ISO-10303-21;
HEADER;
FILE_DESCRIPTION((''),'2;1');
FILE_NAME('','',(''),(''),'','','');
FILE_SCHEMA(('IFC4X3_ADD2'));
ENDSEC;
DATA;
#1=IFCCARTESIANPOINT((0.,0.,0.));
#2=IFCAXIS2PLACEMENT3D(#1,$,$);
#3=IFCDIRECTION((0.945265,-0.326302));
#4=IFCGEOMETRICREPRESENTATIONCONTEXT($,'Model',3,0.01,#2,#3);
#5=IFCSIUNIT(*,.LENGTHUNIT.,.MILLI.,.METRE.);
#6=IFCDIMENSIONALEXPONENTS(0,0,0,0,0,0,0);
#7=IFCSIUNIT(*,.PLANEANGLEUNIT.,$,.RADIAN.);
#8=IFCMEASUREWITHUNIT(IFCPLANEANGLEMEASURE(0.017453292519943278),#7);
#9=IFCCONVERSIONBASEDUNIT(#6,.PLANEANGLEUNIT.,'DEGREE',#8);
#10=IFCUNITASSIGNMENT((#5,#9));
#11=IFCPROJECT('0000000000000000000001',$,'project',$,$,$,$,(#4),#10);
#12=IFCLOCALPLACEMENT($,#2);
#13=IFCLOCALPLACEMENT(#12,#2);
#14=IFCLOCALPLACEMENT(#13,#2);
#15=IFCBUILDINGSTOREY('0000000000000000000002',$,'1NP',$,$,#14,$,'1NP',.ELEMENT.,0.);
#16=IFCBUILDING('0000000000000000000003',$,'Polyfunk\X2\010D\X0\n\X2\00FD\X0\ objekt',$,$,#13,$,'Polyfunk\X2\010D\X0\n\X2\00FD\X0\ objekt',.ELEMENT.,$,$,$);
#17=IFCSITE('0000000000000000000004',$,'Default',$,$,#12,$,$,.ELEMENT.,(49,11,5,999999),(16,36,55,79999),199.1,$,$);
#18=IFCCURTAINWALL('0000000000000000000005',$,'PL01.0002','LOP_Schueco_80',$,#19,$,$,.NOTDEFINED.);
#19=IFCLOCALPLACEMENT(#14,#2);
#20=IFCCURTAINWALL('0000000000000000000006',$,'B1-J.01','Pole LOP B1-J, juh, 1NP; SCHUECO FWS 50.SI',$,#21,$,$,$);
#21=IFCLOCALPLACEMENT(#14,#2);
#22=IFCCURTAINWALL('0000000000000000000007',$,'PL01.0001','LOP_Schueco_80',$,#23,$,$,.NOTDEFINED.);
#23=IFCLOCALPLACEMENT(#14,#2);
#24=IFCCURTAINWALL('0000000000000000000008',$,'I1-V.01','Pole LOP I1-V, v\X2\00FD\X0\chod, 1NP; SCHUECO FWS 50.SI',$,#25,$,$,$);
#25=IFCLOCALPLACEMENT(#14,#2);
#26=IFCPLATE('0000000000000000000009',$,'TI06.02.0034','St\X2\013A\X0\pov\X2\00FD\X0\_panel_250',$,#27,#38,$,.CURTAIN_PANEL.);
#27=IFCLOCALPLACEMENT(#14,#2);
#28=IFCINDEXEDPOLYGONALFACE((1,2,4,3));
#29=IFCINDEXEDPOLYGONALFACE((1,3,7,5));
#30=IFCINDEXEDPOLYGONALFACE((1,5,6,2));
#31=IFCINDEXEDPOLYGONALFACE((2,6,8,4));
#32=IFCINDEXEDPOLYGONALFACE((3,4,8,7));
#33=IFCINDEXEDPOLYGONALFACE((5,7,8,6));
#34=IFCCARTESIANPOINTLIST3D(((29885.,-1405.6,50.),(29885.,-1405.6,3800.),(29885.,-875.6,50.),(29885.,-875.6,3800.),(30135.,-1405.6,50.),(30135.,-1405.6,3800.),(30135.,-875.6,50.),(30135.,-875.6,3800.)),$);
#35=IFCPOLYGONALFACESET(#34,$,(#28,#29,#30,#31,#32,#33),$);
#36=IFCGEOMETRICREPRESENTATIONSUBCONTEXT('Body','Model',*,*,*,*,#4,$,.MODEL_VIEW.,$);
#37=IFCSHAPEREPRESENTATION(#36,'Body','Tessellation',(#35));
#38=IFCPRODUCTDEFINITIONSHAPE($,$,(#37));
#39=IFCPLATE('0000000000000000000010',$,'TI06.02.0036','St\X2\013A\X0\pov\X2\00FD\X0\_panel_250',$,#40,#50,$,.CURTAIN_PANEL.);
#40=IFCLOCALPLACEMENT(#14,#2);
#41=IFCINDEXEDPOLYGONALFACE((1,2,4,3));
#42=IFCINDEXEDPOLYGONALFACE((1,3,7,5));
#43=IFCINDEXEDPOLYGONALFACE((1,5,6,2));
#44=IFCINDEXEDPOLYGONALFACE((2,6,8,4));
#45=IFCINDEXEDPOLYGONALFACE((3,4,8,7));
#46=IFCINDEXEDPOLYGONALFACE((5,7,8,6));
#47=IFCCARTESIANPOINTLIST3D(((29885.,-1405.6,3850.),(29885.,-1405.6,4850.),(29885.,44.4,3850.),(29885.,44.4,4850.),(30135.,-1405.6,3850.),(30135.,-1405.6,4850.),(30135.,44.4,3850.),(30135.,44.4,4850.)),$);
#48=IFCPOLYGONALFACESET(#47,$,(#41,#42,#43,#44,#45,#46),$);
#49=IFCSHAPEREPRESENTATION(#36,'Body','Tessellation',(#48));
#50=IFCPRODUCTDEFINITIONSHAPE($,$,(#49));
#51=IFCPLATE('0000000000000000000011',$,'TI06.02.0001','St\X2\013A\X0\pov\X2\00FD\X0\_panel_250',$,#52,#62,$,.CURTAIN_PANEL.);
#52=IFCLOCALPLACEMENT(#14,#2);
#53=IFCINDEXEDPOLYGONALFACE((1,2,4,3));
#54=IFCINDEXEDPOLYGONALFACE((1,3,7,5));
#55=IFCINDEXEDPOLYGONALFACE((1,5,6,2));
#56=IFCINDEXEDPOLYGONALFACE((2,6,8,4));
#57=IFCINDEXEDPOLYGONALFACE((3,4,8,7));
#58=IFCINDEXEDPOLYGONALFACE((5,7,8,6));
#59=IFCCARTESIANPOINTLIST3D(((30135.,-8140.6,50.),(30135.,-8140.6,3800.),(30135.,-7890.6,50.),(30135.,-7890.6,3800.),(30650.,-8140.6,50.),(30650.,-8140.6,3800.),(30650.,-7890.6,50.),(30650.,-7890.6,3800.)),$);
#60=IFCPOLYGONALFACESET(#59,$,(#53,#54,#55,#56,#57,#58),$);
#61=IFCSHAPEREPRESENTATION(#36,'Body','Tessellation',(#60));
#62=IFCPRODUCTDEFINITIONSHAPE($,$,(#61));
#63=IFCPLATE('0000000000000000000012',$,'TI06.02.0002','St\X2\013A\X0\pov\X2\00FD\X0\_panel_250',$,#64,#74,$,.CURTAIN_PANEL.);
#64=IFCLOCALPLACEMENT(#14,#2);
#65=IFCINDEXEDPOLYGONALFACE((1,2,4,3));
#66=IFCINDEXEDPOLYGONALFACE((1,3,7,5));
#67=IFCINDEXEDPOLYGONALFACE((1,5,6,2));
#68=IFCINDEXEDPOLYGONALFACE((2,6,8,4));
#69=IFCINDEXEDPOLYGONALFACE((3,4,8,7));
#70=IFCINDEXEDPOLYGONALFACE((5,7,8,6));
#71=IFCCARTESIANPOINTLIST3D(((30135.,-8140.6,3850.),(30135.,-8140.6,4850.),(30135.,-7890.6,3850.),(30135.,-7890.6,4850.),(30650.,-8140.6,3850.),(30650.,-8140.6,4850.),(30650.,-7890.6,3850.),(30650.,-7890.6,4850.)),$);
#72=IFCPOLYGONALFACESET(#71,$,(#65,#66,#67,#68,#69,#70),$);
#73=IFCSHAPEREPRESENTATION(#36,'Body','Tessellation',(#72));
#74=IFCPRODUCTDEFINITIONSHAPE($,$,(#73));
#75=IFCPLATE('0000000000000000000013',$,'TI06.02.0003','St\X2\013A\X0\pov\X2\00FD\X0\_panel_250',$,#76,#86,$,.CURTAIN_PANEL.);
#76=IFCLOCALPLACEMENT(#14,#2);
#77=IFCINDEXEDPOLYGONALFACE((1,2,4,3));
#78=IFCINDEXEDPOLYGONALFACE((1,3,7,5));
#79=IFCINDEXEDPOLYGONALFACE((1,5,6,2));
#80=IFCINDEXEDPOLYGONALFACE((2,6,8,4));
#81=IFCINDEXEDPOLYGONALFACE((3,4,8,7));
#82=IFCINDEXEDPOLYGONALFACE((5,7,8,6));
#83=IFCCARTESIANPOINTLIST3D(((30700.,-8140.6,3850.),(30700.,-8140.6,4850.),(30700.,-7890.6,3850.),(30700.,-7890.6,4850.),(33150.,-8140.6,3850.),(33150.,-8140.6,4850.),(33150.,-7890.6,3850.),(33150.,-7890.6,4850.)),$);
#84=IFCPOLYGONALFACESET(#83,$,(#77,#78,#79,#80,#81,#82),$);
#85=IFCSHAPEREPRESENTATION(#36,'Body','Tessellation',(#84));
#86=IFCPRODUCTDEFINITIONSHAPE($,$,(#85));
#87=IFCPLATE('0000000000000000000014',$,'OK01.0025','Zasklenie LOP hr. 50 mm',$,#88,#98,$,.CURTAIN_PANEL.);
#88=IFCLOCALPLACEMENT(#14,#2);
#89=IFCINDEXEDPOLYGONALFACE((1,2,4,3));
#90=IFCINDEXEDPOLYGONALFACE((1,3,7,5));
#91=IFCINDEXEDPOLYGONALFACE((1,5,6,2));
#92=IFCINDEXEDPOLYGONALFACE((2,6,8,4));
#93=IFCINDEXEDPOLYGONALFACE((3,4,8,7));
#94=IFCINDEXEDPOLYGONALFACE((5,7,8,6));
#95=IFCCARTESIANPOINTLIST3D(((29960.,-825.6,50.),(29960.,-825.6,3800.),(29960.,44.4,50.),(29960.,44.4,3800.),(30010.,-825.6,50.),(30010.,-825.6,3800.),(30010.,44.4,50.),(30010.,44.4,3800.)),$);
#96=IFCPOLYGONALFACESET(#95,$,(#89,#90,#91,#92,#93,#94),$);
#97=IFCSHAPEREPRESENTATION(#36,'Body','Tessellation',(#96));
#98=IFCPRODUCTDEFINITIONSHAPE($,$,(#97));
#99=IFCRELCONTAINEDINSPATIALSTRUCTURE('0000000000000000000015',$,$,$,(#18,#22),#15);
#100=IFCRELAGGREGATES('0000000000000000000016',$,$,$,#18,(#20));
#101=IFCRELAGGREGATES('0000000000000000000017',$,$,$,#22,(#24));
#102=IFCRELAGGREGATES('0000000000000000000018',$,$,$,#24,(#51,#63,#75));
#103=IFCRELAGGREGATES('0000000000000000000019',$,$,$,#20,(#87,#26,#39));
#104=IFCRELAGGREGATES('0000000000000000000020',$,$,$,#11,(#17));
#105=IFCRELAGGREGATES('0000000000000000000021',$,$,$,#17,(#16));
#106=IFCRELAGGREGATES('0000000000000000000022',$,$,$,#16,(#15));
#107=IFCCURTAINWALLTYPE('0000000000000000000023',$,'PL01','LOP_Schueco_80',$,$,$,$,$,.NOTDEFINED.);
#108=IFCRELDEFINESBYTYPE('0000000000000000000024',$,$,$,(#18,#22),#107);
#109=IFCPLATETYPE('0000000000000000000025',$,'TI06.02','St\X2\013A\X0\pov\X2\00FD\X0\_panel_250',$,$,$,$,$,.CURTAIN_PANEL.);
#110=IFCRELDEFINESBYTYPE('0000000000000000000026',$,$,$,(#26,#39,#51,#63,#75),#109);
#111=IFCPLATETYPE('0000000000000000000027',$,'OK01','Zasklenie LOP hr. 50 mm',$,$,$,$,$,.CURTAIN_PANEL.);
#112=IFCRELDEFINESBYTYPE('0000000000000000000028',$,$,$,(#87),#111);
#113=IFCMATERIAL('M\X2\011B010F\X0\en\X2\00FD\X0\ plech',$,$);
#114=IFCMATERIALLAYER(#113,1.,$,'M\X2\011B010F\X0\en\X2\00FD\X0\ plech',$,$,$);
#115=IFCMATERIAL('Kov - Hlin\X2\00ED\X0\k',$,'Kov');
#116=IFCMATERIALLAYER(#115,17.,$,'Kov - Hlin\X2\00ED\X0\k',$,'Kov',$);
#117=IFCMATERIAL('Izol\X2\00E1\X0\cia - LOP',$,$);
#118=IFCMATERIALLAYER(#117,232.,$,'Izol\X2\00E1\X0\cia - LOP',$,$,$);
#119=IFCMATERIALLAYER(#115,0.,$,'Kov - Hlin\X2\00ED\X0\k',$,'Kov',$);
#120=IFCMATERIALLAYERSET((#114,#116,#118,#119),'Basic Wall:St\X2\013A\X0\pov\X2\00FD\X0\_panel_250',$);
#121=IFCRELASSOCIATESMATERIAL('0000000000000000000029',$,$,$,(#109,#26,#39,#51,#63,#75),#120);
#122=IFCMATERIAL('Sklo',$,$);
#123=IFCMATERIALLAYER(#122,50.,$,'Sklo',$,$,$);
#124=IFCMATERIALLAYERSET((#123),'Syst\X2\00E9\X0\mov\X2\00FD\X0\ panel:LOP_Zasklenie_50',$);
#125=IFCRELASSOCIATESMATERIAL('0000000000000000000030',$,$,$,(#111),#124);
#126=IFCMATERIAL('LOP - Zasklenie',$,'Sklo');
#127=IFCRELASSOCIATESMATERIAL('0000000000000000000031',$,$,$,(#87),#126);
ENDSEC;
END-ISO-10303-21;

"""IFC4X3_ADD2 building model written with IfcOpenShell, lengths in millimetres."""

from ifc_helpers import new_model, entity, si_unit, converted_unit, direction, frame, frame_2d, origin, place, context, subcontext, project, spatial, rectangle, extrude, source, transform, mapped, material, layer, layer_set, layer_usage, type_object, type_shapes, element, aggregate, save


model = new_model("IFC4X3_ADD2")

# Units and contexts
model_context = context("Model", 3, precision=0.01, world=origin(), true_north=direction((0.945265, -0.326302)))
body_context = subcontext(model_context, "Body", "Model", "MODEL_VIEW")
ifc_project = project(units=[si_unit("LENGTHUNIT", "METRE", prefix="MILLI"), converted_unit("PLANEANGLEUNIT", "DEGREE", entity("IfcPlaneAngleMeasure", 0.017453292519943278), si_unit("PLANEANGLEUNIT", "RADIAN"), dimensions=[0, 0, 0, 0, 0, 0, 0])], contexts=[model_context])

# Site, building, storey
site_placement = place(None, origin())
site = spatial("IfcSite", under=ifc_project, at=site_placement, Name="Default", CompositionType="ELEMENT", RefLatitude=(49, 11, 5, 999999), RefLongitude=(16, 36, 55, 79999), RefElevation=199.1)
building_placement = place(site_placement, origin())
building = spatial("IfcBuilding", under=site, at=building_placement, Name="Polyfunkčný objekt", LongName="Polyfunkčný objekt", CompositionType="ELEMENT")
storey_placement = place(building_placement, origin())
storey = spatial("IfcBuildingStorey", under=building, at=storey_placement, Name="1NP", LongName="1NP", CompositionType="ELEMENT", Elevation=0.0)

# Curtain walls
curtain_wall_type = type_object("IfcCurtainWallType", Name="PL01", Description="LOP_Schueco_80", PredefinedType="NOTDEFINED")
curtain_wall_1_placement = place(storey_placement, origin())
curtain_wall_1 = element("IfcCurtainWall", 1, at=curtain_wall_1_placement, inside=storey, type_object=curtain_wall_type, Name="PL01.0002", Description="LOP_Schueco_80", PredefinedType="NOTDEFINED")
curtain_wall_2 = element("IfcCurtainWall", 2, Name="B1-J.01", Description="Pole LOP B1-J, juh, 1NP; SCHUECO FWS 50.SI")
aggregate(curtain_wall_1, [curtain_wall_2])

# Curtain walls
curtain_wall_3_placement = place(storey_placement, origin())
curtain_wall_3 = element("IfcCurtainWall", 3, at=curtain_wall_3_placement, inside=storey, type_object=curtain_wall_type, Name="PL01.0001", Description="LOP_Schueco_80", PredefinedType="NOTDEFINED")
curtain_wall_4 = element("IfcCurtainWall", 4, Name="I1-V.01", Description="Pole LOP I1-V, východ, 1NP; SCHUECO FWS 50.SI")
aggregate(curtain_wall_3, [curtain_wall_4])

# Plates
ifc_material_1 = material(Name="Měďený plech")
ifc_layer_1 = layer(ifc_material_1, 1.0, Name="Měďený plech")
ifc_material_2 = material(Name="Kov - Hliník", Category="Kov")
ifc_layer_2 = layer(ifc_material_2, 17.0, Name="Kov - Hliník", Category="Kov")
ifc_material_3 = material(Name="Izolácia - LOP")
ifc_layer_3 = layer(ifc_material_3, 232.0, Name="Izolácia - LOP")
ifc_layer_4 = layer(ifc_material_2, 0.0, Name="Kov - Hliník", Category="Kov")
ifc_layer_set_1 = layer_set([ifc_layer_1, ifc_layer_2, ifc_layer_3, ifc_layer_4], Name="Basic Wall:Stĺpový_panel_250")
ifc_layer_usage_1 = layer_usage(ifc_layer_set_1, "AXIS2", "POSITIVE", -125.0)
plate_type_1 = type_object("IfcPlateType", Name="TI06.02", Description="Stĺpový_panel_250", PredefinedType="CURTAIN_PANEL", material=ifc_layer_set_1)
plate_1_placement = place(storey_placement, frame((30010.0, -875.6, 50.0), z_axis=(0.0, 0.0, 1.0), x_axis=(0.0, -1.0, 0.0)))
plate_1 = element("IfcPlate", 5, at=plate_1_placement, type_object=plate_type_1, material=ifc_layer_usage_1, Name="TI06.02.0034", Description="Stĺpový_panel_250", PredefinedType="CURTAIN_PANEL", context=body_context, shape_type="SweptSolid", body=[
    extrude(rectangle(XDim=250.0, YDim=530.0, at=frame_2d((0.0, 0.0), x_axis=(1.0, 0.0))), frame((265.0, 0.0, 0.0), z_axis=(0.0, 0.0, 1.0), x_axis=(0.0, 1.0, 0.0)), (0.0, 0.0, 1.0), 3750.0),
])
ifc_layer_usage_2 = layer_usage(ifc_layer_set_1, "AXIS2", "POSITIVE", -125.0)
plate_2_placement = place(storey_placement, frame((30010.0, 44.4, 3850.0), z_axis=(0.0, 0.0, 1.0), x_axis=(0.0, -1.0, 0.0)))
plate_2 = element("IfcPlate", 6, at=plate_2_placement, type_object=plate_type_1, material=ifc_layer_usage_2, Name="TI06.02.0036", Description="Stĺpový_panel_250", PredefinedType="CURTAIN_PANEL", context=body_context, shape_type="SweptSolid", body=[
    extrude(rectangle(XDim=250.0, YDim=1450.0, at=frame_2d((0.0, 0.0), x_axis=(1.0, 0.0))), frame((725.0, 0.0, 0.0), z_axis=(0.0, 0.0, 1.0), x_axis=(0.0, 1.0, 0.0)), (0.0, 0.0, 1.0), 1000.0),
])
ifc_layer_usage_3 = layer_usage(ifc_layer_set_1, "AXIS2", "POSITIVE", -125.0)
plate_3_placement = place(storey_placement, frame((30135.0, -8015.6, 50.0)))
plate_3 = element("IfcPlate", 7, at=plate_3_placement, type_object=plate_type_1, material=ifc_layer_usage_3, Name="TI06.02.0001", Description="Stĺpový_panel_250", PredefinedType="CURTAIN_PANEL", context=body_context, shape_type="SweptSolid", body=[
    extrude(rectangle(XDim=250.0, YDim=515.0, at=frame_2d((0.0, 0.0), x_axis=(1.0, 0.0))), frame((257.5, 0.0, 0.0), z_axis=(0.0, 0.0, 1.0), x_axis=(0.0, 1.0, 0.0)), (0.0, 0.0, 1.0), 3750.0),
])
ifc_layer_usage_4 = layer_usage(ifc_layer_set_1, "AXIS2", "POSITIVE", -125.0)
plate_4_placement = place(storey_placement, frame((30135.0, -8015.6, 3850.0)))
plate_4 = element("IfcPlate", 8, at=plate_4_placement, type_object=plate_type_1, material=ifc_layer_usage_4, Name="TI06.02.0002", Description="Stĺpový_panel_250", PredefinedType="CURTAIN_PANEL", context=body_context, shape_type="SweptSolid", body=[
    extrude(rectangle(XDim=250.0, YDim=515.0, at=frame_2d((0.0, 0.0), x_axis=(1.0, 0.0))), frame((257.5, 0.0, 0.0), z_axis=(0.0, 0.0, 1.0), x_axis=(0.0, 1.0, 0.0)), (0.0, 0.0, 1.0), 1000.0),
])
ifc_layer_usage_5 = layer_usage(ifc_layer_set_1, "AXIS2", "POSITIVE", -125.0)
plate_5_placement = place(storey_placement, frame((30700.0, -8015.6, 3850.0)))
plate_5 = element("IfcPlate", 9, at=plate_5_placement, type_object=plate_type_1, material=ifc_layer_usage_5, Name="TI06.02.0003", Description="Stĺpový_panel_250", PredefinedType="CURTAIN_PANEL", context=body_context, shape_type="SweptSolid", body=[
    extrude(rectangle(XDim=250.0, YDim=2450.0, at=frame_2d((0.0, 0.0), x_axis=(1.0, 0.0))), frame((1225.0, 0.0, 0.0), z_axis=(0.0, 0.0, 1.0), x_axis=(0.0, 1.0, 0.0)), (0.0, 0.0, 1.0), 1000.0),
])
aggregate(curtain_wall_4, [plate_3, plate_4, plate_5])
ifc_material_4 = material(Name="LOP - Zasklenie", Category="Sklo")
ifc_material_5 = material(Name="Sklo")
ifc_layer_5 = layer(ifc_material_5, 50.0, Name="Sklo")
ifc_layer_set_2 = layer_set([ifc_layer_5], Name="Systémový panel:LOP_Zasklenie_50")
plate_type_2 = type_object("IfcPlateType", Name="OK01", Description="Zasklenie LOP hr. 50 mm", PredefinedType="CURTAIN_PANEL", material=ifc_layer_set_2)
shared_shape_1 = source(origin(), body_context, "Body", "SweptSolid", [
    extrude(rectangle(XDim=3750.0, YDim=870.0, at=frame_2d((-141.7, 0.0), x_axis=(1.0, 0.0))), frame((0.0, -50.0, 2016.7), z_axis=(0.0, 1.0, 0.0), x_axis=(0.0, 0.0, 1.0)), (0.0, 0.0, 1.0), 50.0),
])
type_shapes(plate_type_2, [shared_shape_1])
plate_6_placement = place(curtain_wall_1_placement, frame((30010.0, -390.6, 50.0), z_axis=(0.0, 0.0, 1.0), x_axis=(0.0, -1.0, 0.0)))
plate_6 = element("IfcPlate", 10, at=plate_6_placement, type_object=plate_type_2, material=ifc_material_4, Name="OK01.0025", Description="Zasklenie LOP hr. 50 mm", PredefinedType="CURTAIN_PANEL", context=body_context, shape_type="MappedRepresentation", body=[
    mapped(shared_shape_1, transform((0.0, 0.0, 0.0), scale=1.0)),
])
aggregate(curtain_wall_2, [plate_6, plate_1, plate_2])

save(model, "model.ifc")
